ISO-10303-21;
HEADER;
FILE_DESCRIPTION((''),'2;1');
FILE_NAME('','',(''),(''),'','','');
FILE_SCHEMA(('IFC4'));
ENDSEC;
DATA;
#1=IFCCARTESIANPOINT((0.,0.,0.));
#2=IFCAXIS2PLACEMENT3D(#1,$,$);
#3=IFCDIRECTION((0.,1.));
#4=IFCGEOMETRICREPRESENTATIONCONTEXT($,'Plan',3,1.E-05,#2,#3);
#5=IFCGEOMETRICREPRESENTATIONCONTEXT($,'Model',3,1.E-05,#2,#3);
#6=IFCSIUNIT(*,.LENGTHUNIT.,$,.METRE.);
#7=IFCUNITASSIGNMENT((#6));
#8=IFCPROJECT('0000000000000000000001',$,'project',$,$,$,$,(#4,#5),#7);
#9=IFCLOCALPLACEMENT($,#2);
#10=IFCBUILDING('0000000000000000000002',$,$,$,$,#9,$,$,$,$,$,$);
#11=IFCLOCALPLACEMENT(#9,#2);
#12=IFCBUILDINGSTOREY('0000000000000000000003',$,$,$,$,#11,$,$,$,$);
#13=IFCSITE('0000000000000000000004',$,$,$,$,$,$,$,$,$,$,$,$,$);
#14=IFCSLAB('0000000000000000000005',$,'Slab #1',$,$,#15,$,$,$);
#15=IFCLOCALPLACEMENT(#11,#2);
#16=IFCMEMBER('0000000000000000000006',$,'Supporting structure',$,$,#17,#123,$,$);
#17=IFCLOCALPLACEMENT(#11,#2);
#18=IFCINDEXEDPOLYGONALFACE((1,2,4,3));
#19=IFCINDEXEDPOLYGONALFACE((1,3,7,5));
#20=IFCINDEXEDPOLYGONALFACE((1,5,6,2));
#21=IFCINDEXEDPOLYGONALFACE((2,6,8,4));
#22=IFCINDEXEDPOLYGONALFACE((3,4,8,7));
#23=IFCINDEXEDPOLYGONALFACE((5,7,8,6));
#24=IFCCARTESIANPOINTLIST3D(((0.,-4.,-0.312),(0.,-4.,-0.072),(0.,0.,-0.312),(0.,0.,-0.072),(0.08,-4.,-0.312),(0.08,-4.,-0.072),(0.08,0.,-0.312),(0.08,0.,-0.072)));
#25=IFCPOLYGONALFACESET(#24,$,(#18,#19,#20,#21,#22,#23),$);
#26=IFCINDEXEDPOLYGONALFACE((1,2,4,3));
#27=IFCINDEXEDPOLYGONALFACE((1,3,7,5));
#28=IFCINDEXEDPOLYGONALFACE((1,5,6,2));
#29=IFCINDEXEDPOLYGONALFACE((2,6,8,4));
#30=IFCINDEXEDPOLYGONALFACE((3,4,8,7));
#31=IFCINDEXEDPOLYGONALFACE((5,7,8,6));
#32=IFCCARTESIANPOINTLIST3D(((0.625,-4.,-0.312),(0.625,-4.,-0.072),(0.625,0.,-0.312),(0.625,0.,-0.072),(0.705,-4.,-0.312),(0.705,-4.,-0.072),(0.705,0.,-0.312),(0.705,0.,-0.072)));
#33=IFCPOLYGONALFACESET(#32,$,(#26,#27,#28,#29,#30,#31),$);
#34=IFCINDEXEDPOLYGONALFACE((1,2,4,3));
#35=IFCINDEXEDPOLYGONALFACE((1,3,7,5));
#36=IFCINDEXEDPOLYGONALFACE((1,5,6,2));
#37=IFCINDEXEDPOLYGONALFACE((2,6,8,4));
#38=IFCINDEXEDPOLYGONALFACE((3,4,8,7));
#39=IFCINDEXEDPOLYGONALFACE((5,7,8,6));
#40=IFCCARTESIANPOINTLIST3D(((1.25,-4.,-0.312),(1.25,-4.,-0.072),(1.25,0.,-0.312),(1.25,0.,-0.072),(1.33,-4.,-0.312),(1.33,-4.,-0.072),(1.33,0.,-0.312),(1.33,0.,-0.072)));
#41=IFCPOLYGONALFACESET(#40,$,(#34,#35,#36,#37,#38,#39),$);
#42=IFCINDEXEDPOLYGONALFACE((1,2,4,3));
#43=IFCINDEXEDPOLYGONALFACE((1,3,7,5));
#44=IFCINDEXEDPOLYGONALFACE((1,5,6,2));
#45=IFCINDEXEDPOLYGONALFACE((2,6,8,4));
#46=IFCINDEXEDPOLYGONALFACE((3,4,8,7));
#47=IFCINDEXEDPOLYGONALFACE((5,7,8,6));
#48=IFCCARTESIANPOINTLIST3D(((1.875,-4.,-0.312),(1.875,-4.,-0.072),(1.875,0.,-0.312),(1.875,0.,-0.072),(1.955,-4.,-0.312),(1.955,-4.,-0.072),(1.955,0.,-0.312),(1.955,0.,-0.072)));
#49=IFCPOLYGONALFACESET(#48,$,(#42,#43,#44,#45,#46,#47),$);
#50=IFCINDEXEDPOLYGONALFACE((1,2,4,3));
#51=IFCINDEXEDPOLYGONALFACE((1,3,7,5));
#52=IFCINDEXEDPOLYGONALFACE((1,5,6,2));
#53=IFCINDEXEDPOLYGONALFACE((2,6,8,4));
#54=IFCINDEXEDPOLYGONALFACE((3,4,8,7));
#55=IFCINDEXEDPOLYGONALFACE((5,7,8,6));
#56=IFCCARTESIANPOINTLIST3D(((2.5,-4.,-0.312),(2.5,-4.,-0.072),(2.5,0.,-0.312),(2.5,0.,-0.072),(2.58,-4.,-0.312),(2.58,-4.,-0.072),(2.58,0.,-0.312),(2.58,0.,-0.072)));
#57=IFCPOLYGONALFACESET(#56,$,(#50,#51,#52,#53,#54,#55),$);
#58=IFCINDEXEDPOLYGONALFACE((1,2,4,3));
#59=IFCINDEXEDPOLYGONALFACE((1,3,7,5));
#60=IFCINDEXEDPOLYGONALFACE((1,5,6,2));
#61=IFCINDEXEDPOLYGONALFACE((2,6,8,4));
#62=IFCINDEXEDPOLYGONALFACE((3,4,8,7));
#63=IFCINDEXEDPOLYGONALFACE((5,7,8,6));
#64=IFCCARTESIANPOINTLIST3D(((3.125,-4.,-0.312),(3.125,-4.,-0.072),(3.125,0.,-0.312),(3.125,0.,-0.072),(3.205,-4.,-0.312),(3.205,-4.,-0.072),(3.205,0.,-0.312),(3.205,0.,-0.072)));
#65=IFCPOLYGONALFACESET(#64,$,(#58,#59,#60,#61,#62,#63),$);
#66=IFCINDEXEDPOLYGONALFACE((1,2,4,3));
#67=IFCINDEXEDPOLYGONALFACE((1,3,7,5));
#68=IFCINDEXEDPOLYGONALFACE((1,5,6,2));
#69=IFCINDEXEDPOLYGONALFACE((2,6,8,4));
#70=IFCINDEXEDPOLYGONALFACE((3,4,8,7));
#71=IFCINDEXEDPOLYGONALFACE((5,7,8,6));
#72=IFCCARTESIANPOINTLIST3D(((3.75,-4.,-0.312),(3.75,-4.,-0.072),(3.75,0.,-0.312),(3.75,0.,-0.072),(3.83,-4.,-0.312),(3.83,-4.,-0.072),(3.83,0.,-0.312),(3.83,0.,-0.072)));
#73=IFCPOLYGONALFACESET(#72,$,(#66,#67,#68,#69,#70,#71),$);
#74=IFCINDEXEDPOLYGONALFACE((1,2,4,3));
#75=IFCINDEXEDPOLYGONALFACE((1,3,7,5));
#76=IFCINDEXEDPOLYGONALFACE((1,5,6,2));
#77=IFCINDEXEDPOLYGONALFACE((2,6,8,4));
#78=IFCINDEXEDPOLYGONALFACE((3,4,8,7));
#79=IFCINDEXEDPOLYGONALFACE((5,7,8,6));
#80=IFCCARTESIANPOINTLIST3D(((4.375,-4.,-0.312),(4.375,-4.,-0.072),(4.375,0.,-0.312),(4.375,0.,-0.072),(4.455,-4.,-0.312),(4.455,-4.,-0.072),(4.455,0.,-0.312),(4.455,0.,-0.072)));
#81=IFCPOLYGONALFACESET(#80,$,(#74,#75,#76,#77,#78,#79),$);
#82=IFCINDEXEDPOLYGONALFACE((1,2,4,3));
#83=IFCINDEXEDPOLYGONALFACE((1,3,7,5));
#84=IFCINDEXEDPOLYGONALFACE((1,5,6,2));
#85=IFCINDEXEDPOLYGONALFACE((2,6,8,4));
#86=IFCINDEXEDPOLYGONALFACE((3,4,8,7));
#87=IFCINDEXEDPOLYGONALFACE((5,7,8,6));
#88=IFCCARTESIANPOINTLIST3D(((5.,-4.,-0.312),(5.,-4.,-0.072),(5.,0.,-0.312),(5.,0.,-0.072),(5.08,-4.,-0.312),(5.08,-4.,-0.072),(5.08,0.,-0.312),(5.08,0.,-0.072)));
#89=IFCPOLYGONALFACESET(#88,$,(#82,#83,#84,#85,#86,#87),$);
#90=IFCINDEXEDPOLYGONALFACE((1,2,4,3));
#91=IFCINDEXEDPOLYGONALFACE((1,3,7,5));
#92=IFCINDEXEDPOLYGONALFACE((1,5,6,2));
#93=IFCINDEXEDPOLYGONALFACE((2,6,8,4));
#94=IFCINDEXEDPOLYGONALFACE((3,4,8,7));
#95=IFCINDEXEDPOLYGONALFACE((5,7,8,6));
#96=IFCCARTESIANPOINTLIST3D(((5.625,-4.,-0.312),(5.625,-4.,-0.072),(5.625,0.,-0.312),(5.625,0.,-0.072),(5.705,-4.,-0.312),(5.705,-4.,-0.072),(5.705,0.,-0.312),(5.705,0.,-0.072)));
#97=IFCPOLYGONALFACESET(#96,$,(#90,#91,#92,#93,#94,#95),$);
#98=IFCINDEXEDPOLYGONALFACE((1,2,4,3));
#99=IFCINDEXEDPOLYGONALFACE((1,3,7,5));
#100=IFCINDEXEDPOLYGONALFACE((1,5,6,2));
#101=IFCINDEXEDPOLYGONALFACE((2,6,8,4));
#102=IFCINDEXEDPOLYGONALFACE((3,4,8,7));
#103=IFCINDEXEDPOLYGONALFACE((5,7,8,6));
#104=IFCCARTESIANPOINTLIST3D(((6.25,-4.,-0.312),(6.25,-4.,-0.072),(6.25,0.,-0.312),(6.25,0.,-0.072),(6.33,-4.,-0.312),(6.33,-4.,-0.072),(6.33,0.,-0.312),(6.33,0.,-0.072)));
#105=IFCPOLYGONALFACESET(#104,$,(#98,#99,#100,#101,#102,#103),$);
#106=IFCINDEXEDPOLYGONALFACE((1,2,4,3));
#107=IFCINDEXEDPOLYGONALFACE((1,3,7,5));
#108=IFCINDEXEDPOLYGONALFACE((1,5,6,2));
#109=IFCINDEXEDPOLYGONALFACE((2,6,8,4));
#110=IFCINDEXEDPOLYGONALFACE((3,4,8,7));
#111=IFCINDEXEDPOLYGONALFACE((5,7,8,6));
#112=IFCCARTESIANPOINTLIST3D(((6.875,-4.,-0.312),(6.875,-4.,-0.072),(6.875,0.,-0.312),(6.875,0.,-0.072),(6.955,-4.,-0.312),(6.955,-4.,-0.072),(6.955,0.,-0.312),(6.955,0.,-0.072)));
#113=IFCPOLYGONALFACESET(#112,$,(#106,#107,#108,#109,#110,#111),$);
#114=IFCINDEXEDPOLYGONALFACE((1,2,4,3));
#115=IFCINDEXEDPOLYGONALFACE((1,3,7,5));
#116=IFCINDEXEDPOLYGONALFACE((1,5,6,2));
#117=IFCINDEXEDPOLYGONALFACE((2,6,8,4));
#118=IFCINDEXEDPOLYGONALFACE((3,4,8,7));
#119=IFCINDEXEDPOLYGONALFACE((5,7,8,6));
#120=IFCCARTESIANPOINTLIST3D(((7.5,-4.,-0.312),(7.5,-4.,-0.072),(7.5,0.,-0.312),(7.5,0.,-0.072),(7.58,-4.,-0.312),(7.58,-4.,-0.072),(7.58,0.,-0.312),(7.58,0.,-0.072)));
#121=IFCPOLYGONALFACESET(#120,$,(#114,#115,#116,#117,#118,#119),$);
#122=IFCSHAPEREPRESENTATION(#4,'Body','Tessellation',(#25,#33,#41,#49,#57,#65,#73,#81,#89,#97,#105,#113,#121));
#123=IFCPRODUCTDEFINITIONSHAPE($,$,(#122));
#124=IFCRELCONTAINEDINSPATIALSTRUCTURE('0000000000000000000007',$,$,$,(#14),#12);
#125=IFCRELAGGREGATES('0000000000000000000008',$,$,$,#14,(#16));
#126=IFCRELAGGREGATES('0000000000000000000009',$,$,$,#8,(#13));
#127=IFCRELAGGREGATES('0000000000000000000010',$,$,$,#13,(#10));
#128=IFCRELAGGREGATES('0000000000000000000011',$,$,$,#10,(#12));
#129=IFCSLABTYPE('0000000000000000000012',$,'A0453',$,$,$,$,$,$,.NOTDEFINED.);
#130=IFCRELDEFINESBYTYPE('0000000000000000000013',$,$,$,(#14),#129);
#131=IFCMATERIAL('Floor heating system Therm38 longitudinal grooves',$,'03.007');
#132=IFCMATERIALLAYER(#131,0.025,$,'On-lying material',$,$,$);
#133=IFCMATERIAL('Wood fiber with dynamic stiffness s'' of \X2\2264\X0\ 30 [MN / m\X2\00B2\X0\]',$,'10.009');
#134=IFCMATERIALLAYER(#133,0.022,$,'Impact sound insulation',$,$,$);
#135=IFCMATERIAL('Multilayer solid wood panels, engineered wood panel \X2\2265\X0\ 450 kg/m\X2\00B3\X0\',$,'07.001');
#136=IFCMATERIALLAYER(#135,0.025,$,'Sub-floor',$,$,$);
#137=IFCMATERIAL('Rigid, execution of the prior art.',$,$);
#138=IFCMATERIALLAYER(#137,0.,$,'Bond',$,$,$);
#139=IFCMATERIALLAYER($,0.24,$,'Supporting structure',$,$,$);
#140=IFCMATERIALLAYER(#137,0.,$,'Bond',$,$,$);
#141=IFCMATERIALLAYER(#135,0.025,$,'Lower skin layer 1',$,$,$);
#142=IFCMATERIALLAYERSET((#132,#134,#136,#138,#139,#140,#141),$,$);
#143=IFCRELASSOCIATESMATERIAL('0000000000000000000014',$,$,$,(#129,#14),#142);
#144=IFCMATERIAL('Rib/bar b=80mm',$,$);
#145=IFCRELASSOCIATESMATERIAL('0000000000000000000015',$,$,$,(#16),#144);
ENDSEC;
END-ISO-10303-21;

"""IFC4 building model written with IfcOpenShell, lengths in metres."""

from ifc_helpers import new_model, si_unit, direction, frame, frame_2d, origin, place, context, project, spatial, rectangle, extrude, material, layer, layer_set, type_object, element, aggregate, save


model = new_model("IFC4")

# Units and contexts
plan_context = context("Plan", 3, precision=1e-05, world=origin(), true_north=direction((0.0, 1.0)))
model_context = context("Model", 3, precision=1e-05, world=origin(), true_north=direction((0.0, 1.0)))
ifc_project = project(units=[si_unit("LENGTHUNIT", "METRE")], contexts=[plan_context, model_context])

# Site, building, storey
site = spatial("IfcSite", under=ifc_project)
building_placement = place(None, origin())
building = spatial("IfcBuilding", under=site, at=building_placement)
storey_placement = place(building_placement, origin())
storey = spatial("IfcBuildingStorey", under=building, at=storey_placement)

# Slab, member
ifc_material_1 = material(Name="Floor heating system Therm38 longitudinal grooves", Category="03.007")
ifc_layer_1 = layer(ifc_material_1, 0.025, Name="On-lying material")
ifc_material_2 = material(Name="Wood fiber with dynamic stiffness s' of ≤ 30 [MN / m²]", Category="10.009")
ifc_layer_2 = layer(ifc_material_2, 0.022, Name="Impact sound insulation")
ifc_material_3 = material(Name="Multilayer solid wood panels, engineered wood panel ≥ 450 kg/m³", Category="07.001")
ifc_layer_3 = layer(ifc_material_3, 0.025, Name="Sub-floor")
ifc_material_4 = material(Name="Rigid, execution of the prior art.")
ifc_layer_4 = layer(ifc_material_4, 0.0, Name="Bond")
ifc_layer_5 = layer(None, 0.24, Name="Supporting structure")
ifc_layer_6 = layer(ifc_material_4, 0.0, Name="Bond")
ifc_layer_7 = layer(ifc_material_3, 0.025, Name="Lower skin layer 1")
ifc_layer_set = layer_set([ifc_layer_1, ifc_layer_2, ifc_layer_3, ifc_layer_4, ifc_layer_5, ifc_layer_6, ifc_layer_7])
slab_type = type_object("IfcSlabType", Name="A0453", PredefinedType="NOTDEFINED", material=ifc_layer_set)
slab_placement = place(None, frame((0.0, 0.0, 0.0), z_axis=(0.0, 0.0, -1.0), x_axis=(1.0, 0.0, 0.0)))
slab = element("IfcSlab", 1, at=slab_placement, inside=storey, type_object=slab_type, material=ifc_layer_set, Name="Slab #1")
ifc_material_5 = material(Name="Rib/bar b=80mm")
member_1_placement = place(slab_placement, origin())
member_1 = element("IfcMember", 2, at=member_1_placement, material=ifc_material_5, Name="Supporting structure", context=plan_context, shape_type="SweptSolid", body=[
    extrude(rectangle(XDim=0.08, YDim=0.24, at=frame_2d((0.04, 0.12), x_axis=(1.0, 0.0))), frame((0.0, 4.0, 0.072), z_axis=(0.0, -1.0, 0.0), x_axis=(1.0, 0.0, 0.0)), (0.0, 0.0, 1.0), 4.0),
    extrude(rectangle(XDim=0.08, YDim=0.24, at=frame_2d((0.04, 0.12), x_axis=(1.0, 0.0))), frame((0.625, 4.0, 0.072), z_axis=(0.0, -1.0, 0.0), x_axis=(1.0, 0.0, 0.0)), (0.0, 0.0, 1.0), 4.0),
    extrude(rectangle(XDim=0.08, YDim=0.24, at=frame_2d((0.04, 0.12), x_axis=(1.0, 0.0))), frame((1.25, 4.0, 0.072), z_axis=(0.0, -1.0, 0.0), x_axis=(1.0, 0.0, 0.0)), (0.0, 0.0, 1.0), 4.0),
    extrude(rectangle(XDim=0.08, YDim=0.24, at=frame_2d((0.04, 0.12), x_axis=(1.0, 0.0))), frame((1.875, 4.0, 0.072), z_axis=(0.0, -1.0, 0.0), x_axis=(1.0, 0.0, 0.0)), (0.0, 0.0, 1.0), 4.0),
    extrude(rectangle(XDim=0.08, YDim=0.24, at=frame_2d((0.04, 0.12), x_axis=(1.0, 0.0))), frame((2.5, 4.0, 0.072), z_axis=(0.0, -1.0, 0.0), x_axis=(1.0, 0.0, 0.0)), (0.0, 0.0, 1.0), 4.0),
    extrude(rectangle(XDim=0.08, YDim=0.24, at=frame_2d((0.04, 0.12), x_axis=(1.0, 0.0))), frame((3.125, 4.0, 0.072), z_axis=(0.0, -1.0, 0.0), x_axis=(1.0, 0.0, 0.0)), (0.0, 0.0, 1.0), 4.0),
    extrude(rectangle(XDim=0.08, YDim=0.24, at=frame_2d((0.04, 0.12), x_axis=(1.0, 0.0))), frame((3.75, 4.0, 0.072), z_axis=(0.0, -1.0, 0.0), x_axis=(1.0, 0.0, 0.0)), (0.0, 0.0, 1.0), 4.0),
    extrude(rectangle(XDim=0.08, YDim=0.24, at=frame_2d((0.04, 0.12), x_axis=(1.0, 0.0))), frame((4.375, 4.0, 0.072), z_axis=(0.0, -1.0, 0.0), x_axis=(1.0, 0.0, 0.0)), (0.0, 0.0, 1.0), 4.0),
    extrude(rectangle(XDim=0.08, YDim=0.24, at=frame_2d((0.04, 0.12), x_axis=(1.0, 0.0))), frame((5.0, 4.0, 0.072), z_axis=(0.0, -1.0, 0.0), x_axis=(1.0, 0.0, 0.0)), (0.0, 0.0, 1.0), 4.0),
    extrude(rectangle(XDim=0.08, YDim=0.24, at=frame_2d((0.04, 0.12), x_axis=(1.0, 0.0))), frame((5.625, 4.0, 0.072), z_axis=(0.0, -1.0, 0.0), x_axis=(1.0, 0.0, 0.0)), (0.0, 0.0, 1.0), 4.0),
    extrude(rectangle(XDim=0.08, YDim=0.24, at=frame_2d((0.04, 0.12), x_axis=(1.0, 0.0))), frame((6.25, 4.0, 0.072), z_axis=(0.0, -1.0, 0.0), x_axis=(1.0, 0.0, 0.0)), (0.0, 0.0, 1.0), 4.0),
    extrude(rectangle(XDim=0.08, YDim=0.24, at=frame_2d((0.04, 0.12), x_axis=(1.0, 0.0))), frame((6.875, 4.0, 0.072), z_axis=(0.0, -1.0, 0.0), x_axis=(1.0, 0.0, 0.0)), (0.0, 0.0, 1.0), 4.0),
    extrude(rectangle(XDim=0.08, YDim=0.24, at=frame_2d((0.04, 0.12), x_axis=(1.0, 0.0))), frame((7.5, 4.0, 0.072), z_axis=(0.0, -1.0, 0.0), x_axis=(1.0, 0.0, 0.0)), (0.0, 0.0, 1.0), 4.0),
])
aggregate(slab, [member_1])

save(model, "model.ifc")
